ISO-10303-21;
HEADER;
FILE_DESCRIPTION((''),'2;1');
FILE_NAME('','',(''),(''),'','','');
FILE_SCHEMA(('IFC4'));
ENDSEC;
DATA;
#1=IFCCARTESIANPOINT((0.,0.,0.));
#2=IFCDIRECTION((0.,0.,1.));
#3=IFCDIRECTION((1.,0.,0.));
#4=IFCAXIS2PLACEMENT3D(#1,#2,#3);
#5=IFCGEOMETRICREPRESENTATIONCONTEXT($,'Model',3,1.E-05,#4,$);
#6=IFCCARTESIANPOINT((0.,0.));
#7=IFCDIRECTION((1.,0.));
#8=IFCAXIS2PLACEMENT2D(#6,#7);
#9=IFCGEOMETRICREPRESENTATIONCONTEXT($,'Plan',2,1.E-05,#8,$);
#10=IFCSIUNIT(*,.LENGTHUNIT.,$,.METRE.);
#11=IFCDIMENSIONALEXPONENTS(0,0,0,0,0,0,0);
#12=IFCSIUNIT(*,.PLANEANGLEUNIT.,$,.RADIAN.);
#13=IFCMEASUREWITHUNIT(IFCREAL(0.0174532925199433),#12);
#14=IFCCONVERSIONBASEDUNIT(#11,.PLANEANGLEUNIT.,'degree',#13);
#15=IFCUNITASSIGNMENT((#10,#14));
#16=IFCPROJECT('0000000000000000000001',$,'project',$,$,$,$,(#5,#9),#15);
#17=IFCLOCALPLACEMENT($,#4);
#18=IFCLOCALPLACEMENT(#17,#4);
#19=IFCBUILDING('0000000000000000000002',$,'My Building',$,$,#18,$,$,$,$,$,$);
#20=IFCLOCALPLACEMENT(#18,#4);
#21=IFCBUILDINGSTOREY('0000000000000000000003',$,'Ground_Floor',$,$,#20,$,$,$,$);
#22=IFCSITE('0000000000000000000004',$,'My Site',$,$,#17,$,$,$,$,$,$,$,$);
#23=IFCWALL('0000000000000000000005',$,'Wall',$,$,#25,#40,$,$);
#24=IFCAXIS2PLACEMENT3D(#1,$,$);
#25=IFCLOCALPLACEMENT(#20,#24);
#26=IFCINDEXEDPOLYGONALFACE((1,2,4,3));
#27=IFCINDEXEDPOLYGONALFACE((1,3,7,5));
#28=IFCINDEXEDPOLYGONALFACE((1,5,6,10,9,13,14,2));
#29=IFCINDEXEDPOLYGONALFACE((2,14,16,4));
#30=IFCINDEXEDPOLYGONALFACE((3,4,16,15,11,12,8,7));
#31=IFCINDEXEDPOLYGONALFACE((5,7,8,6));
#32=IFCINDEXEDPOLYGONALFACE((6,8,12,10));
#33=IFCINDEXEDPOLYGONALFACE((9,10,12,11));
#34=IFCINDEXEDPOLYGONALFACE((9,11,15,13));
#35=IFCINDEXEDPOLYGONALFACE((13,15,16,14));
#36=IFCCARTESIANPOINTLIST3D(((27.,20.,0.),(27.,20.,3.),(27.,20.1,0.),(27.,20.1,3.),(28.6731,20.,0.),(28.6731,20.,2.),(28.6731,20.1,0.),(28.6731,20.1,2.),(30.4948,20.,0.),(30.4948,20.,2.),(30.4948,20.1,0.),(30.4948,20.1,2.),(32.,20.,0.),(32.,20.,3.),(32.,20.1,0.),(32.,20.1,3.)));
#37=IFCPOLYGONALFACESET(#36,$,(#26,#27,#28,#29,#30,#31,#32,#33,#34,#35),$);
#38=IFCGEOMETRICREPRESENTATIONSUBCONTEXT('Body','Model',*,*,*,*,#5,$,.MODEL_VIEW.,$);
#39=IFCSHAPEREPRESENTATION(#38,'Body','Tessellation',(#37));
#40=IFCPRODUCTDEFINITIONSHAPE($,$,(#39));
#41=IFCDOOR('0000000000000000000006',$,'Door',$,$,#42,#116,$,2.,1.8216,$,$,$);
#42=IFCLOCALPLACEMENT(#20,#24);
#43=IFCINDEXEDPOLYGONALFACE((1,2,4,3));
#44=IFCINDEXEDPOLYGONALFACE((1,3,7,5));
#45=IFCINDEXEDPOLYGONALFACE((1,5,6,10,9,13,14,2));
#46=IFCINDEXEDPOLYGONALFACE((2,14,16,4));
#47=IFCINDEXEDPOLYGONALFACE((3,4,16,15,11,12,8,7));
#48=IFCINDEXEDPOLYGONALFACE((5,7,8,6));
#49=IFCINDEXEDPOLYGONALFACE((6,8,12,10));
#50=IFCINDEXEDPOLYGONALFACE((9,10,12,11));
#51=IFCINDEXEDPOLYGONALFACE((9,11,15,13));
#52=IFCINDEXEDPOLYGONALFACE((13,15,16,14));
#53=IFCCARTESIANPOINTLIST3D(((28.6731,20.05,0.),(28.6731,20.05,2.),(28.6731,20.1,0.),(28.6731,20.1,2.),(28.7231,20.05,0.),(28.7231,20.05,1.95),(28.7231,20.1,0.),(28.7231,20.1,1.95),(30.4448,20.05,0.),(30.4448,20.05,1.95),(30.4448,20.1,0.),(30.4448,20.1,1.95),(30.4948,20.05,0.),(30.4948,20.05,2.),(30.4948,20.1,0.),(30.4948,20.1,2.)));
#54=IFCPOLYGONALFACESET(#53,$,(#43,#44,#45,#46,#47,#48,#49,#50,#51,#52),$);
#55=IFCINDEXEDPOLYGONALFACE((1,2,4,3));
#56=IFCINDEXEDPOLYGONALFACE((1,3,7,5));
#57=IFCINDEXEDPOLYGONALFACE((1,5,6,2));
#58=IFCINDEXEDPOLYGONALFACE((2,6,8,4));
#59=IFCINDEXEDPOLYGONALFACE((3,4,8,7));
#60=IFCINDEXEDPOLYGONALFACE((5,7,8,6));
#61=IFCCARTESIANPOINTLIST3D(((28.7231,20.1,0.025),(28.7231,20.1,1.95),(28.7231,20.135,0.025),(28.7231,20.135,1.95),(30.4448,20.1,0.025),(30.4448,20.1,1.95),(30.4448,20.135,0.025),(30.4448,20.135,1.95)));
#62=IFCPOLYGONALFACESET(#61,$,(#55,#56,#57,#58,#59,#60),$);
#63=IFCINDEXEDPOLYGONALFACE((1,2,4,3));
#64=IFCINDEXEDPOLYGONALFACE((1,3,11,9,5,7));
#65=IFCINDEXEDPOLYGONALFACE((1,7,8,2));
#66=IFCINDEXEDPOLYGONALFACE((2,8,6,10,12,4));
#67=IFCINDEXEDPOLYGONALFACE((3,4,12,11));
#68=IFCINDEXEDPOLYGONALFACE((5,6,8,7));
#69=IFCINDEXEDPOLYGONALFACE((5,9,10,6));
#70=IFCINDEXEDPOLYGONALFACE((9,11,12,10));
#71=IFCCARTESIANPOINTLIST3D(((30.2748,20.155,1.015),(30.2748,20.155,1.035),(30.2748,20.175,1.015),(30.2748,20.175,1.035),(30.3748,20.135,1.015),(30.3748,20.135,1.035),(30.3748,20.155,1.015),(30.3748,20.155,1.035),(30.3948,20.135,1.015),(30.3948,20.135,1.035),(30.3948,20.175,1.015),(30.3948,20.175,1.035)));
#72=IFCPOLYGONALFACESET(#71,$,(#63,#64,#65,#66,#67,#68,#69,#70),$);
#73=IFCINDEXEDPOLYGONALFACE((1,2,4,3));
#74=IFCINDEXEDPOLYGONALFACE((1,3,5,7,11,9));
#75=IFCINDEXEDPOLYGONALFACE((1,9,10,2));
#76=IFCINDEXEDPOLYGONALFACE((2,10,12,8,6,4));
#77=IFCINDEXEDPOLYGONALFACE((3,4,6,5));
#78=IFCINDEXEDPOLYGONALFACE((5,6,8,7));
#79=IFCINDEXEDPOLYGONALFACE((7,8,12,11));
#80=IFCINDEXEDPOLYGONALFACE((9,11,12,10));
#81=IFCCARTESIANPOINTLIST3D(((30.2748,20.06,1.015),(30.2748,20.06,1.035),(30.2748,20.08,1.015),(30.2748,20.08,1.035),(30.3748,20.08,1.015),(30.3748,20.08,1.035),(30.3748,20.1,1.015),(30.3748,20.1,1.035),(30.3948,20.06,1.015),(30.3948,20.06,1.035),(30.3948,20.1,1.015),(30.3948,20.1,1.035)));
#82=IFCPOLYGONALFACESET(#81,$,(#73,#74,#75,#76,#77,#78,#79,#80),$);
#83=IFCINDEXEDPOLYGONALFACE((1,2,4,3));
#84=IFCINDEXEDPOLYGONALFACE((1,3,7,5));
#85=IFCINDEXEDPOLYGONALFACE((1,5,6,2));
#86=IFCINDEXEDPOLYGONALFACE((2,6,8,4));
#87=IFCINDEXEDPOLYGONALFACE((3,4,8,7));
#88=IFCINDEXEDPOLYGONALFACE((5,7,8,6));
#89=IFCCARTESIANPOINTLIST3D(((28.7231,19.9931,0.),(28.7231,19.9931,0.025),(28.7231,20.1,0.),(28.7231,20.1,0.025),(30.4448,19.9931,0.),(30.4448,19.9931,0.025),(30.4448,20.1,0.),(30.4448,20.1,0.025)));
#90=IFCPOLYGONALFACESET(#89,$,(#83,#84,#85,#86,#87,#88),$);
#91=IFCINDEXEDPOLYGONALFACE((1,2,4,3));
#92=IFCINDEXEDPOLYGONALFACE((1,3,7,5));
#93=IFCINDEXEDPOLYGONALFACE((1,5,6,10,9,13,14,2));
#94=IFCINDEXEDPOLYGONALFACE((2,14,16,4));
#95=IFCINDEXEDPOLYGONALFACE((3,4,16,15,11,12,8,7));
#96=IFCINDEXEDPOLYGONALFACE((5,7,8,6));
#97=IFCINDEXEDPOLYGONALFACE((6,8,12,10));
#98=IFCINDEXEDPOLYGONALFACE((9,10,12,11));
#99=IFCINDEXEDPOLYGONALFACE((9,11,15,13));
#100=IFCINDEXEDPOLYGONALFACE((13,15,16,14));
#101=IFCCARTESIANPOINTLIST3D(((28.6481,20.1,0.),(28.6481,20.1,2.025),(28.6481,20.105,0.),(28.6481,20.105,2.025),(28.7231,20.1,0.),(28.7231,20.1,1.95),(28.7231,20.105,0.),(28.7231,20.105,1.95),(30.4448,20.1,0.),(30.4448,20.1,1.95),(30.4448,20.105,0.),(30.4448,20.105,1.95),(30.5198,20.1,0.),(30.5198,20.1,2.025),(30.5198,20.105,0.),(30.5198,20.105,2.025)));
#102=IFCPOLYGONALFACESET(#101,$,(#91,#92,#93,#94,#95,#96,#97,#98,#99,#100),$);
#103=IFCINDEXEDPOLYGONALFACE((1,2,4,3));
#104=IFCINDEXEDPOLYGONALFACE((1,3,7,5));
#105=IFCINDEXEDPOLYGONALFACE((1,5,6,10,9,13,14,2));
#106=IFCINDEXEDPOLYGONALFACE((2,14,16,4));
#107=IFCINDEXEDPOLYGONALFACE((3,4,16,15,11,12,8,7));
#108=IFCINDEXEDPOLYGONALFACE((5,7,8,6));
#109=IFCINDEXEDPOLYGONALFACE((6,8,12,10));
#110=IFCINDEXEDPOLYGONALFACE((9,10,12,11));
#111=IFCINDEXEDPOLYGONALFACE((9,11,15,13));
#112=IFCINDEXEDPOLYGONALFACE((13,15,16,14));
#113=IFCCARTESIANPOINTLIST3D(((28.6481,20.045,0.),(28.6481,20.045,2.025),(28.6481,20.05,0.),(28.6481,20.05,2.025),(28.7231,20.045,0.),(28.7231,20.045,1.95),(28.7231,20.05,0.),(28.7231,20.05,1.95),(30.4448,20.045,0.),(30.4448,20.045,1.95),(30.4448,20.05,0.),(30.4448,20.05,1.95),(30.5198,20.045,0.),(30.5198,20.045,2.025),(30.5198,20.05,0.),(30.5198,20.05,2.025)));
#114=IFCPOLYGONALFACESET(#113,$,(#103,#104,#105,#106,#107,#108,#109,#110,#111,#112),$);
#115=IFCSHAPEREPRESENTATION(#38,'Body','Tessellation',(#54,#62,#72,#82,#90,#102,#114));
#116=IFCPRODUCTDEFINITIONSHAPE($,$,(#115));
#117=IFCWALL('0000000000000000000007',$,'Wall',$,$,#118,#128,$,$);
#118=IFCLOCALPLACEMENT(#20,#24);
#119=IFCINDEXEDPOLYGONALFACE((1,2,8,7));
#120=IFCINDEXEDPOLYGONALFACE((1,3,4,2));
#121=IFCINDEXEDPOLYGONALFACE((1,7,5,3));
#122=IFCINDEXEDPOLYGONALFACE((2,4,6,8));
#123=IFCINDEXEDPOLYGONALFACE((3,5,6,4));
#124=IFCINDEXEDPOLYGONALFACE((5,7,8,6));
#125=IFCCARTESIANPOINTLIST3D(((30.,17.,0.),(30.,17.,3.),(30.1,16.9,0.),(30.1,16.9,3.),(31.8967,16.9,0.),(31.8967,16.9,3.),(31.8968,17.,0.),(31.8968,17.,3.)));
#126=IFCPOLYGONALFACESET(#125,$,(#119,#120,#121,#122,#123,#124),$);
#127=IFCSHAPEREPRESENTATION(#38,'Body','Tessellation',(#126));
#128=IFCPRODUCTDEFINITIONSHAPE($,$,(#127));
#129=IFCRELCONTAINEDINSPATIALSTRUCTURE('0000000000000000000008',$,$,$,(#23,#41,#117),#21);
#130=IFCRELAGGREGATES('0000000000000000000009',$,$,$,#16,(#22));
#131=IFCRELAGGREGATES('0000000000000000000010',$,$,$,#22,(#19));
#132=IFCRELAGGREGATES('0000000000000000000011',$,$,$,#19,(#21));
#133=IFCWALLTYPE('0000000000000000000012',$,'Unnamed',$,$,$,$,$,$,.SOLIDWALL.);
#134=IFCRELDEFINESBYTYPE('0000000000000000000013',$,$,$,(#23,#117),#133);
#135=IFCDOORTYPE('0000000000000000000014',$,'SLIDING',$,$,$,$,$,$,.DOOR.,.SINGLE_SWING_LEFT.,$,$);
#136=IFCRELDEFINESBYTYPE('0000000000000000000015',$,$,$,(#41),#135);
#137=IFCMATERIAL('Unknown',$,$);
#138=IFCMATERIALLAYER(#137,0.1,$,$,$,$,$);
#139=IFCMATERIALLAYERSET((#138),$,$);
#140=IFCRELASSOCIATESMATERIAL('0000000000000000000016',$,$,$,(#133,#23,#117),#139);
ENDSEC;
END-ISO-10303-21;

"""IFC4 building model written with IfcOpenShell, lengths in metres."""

from ifc_helpers import new_model, entity, si_unit, converted_unit, frame, origin_with_axes, origin_2d_with_axis, place, context, subcontext, project, spatial, line, indexed_curve, outline, extrude, shape, source, transform, mapped, material, layer, layer_set, layer_usage, type_object, type_shapes, element, fill, save


model = new_model("IFC4")

# Units and contexts
model_context = context("Model", 3, precision=1e-05, world=origin_with_axes())
plan_context = context("Plan", 2, precision=1e-05, world=origin_2d_with_axis())
body_context_1 = subcontext(model_context, "Body", "Model", "MODEL_VIEW")
body_context_2 = subcontext(plan_context, "Body", "Plan", "PLAN_VIEW")
ifc_project = project(units=[si_unit("LENGTHUNIT", "METRE"), converted_unit("PLANEANGLEUNIT", "degree", entity("IfcReal", 0.0174532925199433), si_unit("PLANEANGLEUNIT", "RADIAN"), dimensions=[0, 0, 0, 0, 0, 0, 0])], contexts=[model_context, plan_context])

# Site, building, storey
site_placement = place(None, origin_with_axes())
site = spatial("IfcSite", under=ifc_project, at=site_placement, Name="My Site")
building_placement = place(site_placement, origin_with_axes())
building = spatial("IfcBuilding", under=site, at=building_placement, Name="My Building")
storey_placement = place(building_placement, origin_with_axes())
storey = spatial("IfcBuildingStorey", under=building, at=storey_placement, Name="Ground_Floor")

# Shared definitions
ifc_material = material(Name="Unknown")
ifc_layer = layer(ifc_material, 0.1)
ifc_layer_set = layer_set([ifc_layer])
wall_type = type_object("IfcWallType", Name="Unnamed", PredefinedType="SOLIDWALL", material=ifc_layer_set)

# Wall, opening, door
ifc_layer_usage_1 = layer_usage(ifc_layer_set, "AXIS2", "POSITIVE", 0.0)
wall_1_placement = place(storey_placement, frame((27.0, 20.0, 0.0), z_axis=(0.0, 0.0, 1.0), x_axis=(1.0, 0.0, 0.0)))
wall_1 = element("IfcWall", 1, at=wall_1_placement, inside=storey, type_object=wall_type, material=ifc_layer_usage_1, Name="Wall", context=body_context_1, shape_type="SweptSolid", body=[
    extrude(outline(indexed_curve([(0.0, 0.0), (0.0, 0.1), (5.0, 0.1), (5.0, 0.0)], segments=[line(1, 2, 3, 4, 1)])), origin_with_axes(), (0.0, 0.0, 1.0), 3.0),
])
shared_shape_1 = source(origin_with_axes(), body_context_1, "Body", "SweptSolid", [
    extrude(outline(indexed_curve([(0.0, 0.0), (1.8216, 0.0), (1.8216, 2.0), (0.0, 2.0)], segments=[line(1, 2, 3, 4, 1)])), frame((0.0, -0.6, 0.0), z_axis=(0.0, -1.0, 0.0), x_axis=(1.0, 0.0, 0.0)), (0.0, 0.0, -1.0), 1.2),
])
opening_1_placement = place(wall_1_placement, frame((3.4948, 0.1, 0.0), z_axis=(0.0, 0.0, 1.0), x_axis=(-1.0, 0.0, 0.0)))
opening_1 = element("IfcOpeningElement", 2, at=opening_1_placement, cuts=wall_1, PredefinedType="OPENING", context=body_context_1, shape_type="MappedRepresentation", body=[
    mapped(shared_shape_1, transform((0.0, 0.0, 0.0), x_axis=(1.0, 0.0, 0.0), y_axis=(0.0, 1.0, 0.0), z_axis=(0.0, 0.0, 1.0), scale=1.0)),
])
door_type_1 = type_object("IfcDoorType", Name="SLIDING", OperationType="SINGLE_SWING_LEFT", PredefinedType="DOOR")
shared_shape_2 = source(origin_with_axes(), body_context_1, "Body", "SweptSolid", [
    extrude(outline(indexed_curve([(0.0, 0.0), (0.0, 2.0), (1.8216, 2.0), (1.8216, 0.0), (1.7716, 0.0), (1.7716, 1.95), (0.05, 1.95), (0.05, 0.0)], segments=[line(1, 2, 3, 4, 5, 6, 7, 8, 1)])), frame((0.0, 0.0, 0.0), z_axis=(0.0, -1.0, 0.0), x_axis=(1.0, 0.0, 0.0)), (0.0, 0.0, -1.0), 0.05),
    extrude(outline(indexed_curve([(0.0, 0.0), (1.7216, 0.0), (1.7216, 0.035), (0.0, 0.035)], segments=[line(1, 2, 3, 4, 1)])), frame((0.05, -0.035, 0.025), z_axis=(0.0, 0.0, 1.0), x_axis=(1.0, 0.0, 0.0)), (0.0, 0.0, 1.0), 1.925),
    extrude(outline(indexed_curve([(0.0, 0.0), (0.0, -0.04), (0.12, -0.04), (0.12, -0.02), (0.02, -0.02), (0.02, 0.0)], segments=[line(1, 2, 3, 4, 5, 6, 1)])), frame((0.1, -0.035, 1.015), z_axis=(0.0, 0.0, 1.0), x_axis=(1.0, 0.0, 0.0)), (0.0, 0.0, 1.0), 0.02),
    extrude(outline(indexed_curve([(0.0, 0.0), (0.0, 0.04), (0.12, 0.04), (0.12, 0.02), (0.02, 0.02), (0.02, 0.0)], segments=[line(1, 2, 3, 4, 5, 6, 1)])), frame((0.1, 0.0, 1.015), z_axis=(0.0, 0.0, 1.0), x_axis=(1.0, 0.0, 0.0)), (0.0, 0.0, 1.0), 0.02),
    extrude(outline(indexed_curve([(0.0, 0.0), (1.7216, 0.0), (1.7216, 0.1069), (0.0, 0.1069)], segments=[line(1, 2, 3, 4, 1)])), frame((0.05, 0.0, 0.0), z_axis=(0.0, 0.0, 1.0), x_axis=(1.0, 0.0, 0.0)), (0.0, 0.0, 1.0), 0.025),
    extrude(outline(indexed_curve([(0.0, 0.0), (0.0, 2.025), (1.8716, 2.025), (1.8716, 0.0), (1.7966, 0.0), (1.7966, 1.95), (0.075, 1.95), (0.075, 0.0)], segments=[line(1, 2, 3, 4, 5, 6, 7, 8, 1)])), frame((-0.025, -0.005, 0.0), z_axis=(0.0, -1.0, 0.0), x_axis=(1.0, 0.0, 0.0)), (0.0, 0.0, -1.0), 0.005),
    extrude(outline(indexed_curve([(0.0, 0.0), (0.0, 2.025), (1.8716, 2.025), (1.8716, 0.0), (1.7966, 0.0), (1.7966, 1.95), (0.075, 1.95), (0.075, 0.0)], segments=[line(1, 2, 3, 4, 5, 6, 7, 8, 1)])), frame((-0.025, 0.05, 0.0), z_axis=(0.0, -1.0, 0.0), x_axis=(1.0, 0.0, 0.0)), (0.0, 0.0, -1.0), 0.005),
])
shared_shape_3 = source(origin_with_axes(), body_context_2, "Body", "Curve2D", [
    entity("IfcIndexedPolyCurve", entity("IfcCartesianPointList2D", [[0.0, 0.0], [0.05, 0.0], [0.05, 0.05], [0.0, 0.05]]), [entity("IfcLineIndex", [1, 2, 3, 4, 1])]),
    entity("IfcIndexedPolyCurve", entity("IfcCartesianPointList2D", [[1.8216, 0.0], [1.7716, 0.0], [1.7716, 0.05], [1.8216, 0.05]]), [entity("IfcLineIndex", [1, 2, 3, 4, 1])]),
    entity("IfcIndexedPolyCurve", entity("IfcCartesianPointList2D", [[2.6325, -0.035], [0.9108, -0.035], [0.9108, 0.0], [2.6325, 0.0]]), [entity("IfcLineIndex", [1, 2, 3, 4, 1])]),
])
type_shapes(door_type_1, [shared_shape_2, shared_shape_3])
door_1_placement = place(opening_1_placement, frame((0.0, 0.0, 0.0), z_axis=(0.0, 0.0, 1.0), x_axis=(1.0, 0.0, 0.0)))
door_1 = element("IfcDoor", 3, at=door_1_placement, inside=storey, type_object=door_type_1, Name="Door", OverallHeight=2.0, OverallWidth=1.8216, shapes=[
    shape(body_context_1, "Body", "MappedRepresentation", [mapped(shared_shape_2, transform((0.0, 0.0, 0.0), x_axis=(1.0, 0.0, 0.0), y_axis=(0.0, 1.0, 0.0), z_axis=(0.0, 0.0, 1.0), scale=1.0))]),
    shape(body_context_2, "Body", "MappedRepresentation", [mapped(shared_shape_3, transform((0.0, 0.0, 0.0), x_axis=(1.0, 0.0, 0.0), y_axis=(0.0, 1.0, 0.0), z_axis=(0.0, 0.0, 1.0), scale=1.0))]),
])
fill(opening_1, door_1)

# Wall
ifc_layer_usage_2 = layer_usage(ifc_layer_set, "AXIS2", "POSITIVE", 0.0)
wall_2_placement = place(storey_placement, frame((31.8968, 17.0, 0.0), z_axis=(0.0, 0.0, 1.0), x_axis=(-1.0, 0.0, 0.0)))
element("IfcWall", 4, at=wall_2_placement, inside=storey, type_object=wall_type, material=ifc_layer_usage_2, Name="Wall", context=body_context_1, shape_type="SweptSolid", body=[
    extrude(outline(indexed_curve([(0.0, 0.0), (0.0001, 0.1), (1.7968, 0.1), (1.8968, 0.0)], segments=[line(1, 2, 3, 4, 1)])), origin_with_axes(), (0.0, 0.0, 1.0), 3.0),
])

save(model, "model.ifc")
